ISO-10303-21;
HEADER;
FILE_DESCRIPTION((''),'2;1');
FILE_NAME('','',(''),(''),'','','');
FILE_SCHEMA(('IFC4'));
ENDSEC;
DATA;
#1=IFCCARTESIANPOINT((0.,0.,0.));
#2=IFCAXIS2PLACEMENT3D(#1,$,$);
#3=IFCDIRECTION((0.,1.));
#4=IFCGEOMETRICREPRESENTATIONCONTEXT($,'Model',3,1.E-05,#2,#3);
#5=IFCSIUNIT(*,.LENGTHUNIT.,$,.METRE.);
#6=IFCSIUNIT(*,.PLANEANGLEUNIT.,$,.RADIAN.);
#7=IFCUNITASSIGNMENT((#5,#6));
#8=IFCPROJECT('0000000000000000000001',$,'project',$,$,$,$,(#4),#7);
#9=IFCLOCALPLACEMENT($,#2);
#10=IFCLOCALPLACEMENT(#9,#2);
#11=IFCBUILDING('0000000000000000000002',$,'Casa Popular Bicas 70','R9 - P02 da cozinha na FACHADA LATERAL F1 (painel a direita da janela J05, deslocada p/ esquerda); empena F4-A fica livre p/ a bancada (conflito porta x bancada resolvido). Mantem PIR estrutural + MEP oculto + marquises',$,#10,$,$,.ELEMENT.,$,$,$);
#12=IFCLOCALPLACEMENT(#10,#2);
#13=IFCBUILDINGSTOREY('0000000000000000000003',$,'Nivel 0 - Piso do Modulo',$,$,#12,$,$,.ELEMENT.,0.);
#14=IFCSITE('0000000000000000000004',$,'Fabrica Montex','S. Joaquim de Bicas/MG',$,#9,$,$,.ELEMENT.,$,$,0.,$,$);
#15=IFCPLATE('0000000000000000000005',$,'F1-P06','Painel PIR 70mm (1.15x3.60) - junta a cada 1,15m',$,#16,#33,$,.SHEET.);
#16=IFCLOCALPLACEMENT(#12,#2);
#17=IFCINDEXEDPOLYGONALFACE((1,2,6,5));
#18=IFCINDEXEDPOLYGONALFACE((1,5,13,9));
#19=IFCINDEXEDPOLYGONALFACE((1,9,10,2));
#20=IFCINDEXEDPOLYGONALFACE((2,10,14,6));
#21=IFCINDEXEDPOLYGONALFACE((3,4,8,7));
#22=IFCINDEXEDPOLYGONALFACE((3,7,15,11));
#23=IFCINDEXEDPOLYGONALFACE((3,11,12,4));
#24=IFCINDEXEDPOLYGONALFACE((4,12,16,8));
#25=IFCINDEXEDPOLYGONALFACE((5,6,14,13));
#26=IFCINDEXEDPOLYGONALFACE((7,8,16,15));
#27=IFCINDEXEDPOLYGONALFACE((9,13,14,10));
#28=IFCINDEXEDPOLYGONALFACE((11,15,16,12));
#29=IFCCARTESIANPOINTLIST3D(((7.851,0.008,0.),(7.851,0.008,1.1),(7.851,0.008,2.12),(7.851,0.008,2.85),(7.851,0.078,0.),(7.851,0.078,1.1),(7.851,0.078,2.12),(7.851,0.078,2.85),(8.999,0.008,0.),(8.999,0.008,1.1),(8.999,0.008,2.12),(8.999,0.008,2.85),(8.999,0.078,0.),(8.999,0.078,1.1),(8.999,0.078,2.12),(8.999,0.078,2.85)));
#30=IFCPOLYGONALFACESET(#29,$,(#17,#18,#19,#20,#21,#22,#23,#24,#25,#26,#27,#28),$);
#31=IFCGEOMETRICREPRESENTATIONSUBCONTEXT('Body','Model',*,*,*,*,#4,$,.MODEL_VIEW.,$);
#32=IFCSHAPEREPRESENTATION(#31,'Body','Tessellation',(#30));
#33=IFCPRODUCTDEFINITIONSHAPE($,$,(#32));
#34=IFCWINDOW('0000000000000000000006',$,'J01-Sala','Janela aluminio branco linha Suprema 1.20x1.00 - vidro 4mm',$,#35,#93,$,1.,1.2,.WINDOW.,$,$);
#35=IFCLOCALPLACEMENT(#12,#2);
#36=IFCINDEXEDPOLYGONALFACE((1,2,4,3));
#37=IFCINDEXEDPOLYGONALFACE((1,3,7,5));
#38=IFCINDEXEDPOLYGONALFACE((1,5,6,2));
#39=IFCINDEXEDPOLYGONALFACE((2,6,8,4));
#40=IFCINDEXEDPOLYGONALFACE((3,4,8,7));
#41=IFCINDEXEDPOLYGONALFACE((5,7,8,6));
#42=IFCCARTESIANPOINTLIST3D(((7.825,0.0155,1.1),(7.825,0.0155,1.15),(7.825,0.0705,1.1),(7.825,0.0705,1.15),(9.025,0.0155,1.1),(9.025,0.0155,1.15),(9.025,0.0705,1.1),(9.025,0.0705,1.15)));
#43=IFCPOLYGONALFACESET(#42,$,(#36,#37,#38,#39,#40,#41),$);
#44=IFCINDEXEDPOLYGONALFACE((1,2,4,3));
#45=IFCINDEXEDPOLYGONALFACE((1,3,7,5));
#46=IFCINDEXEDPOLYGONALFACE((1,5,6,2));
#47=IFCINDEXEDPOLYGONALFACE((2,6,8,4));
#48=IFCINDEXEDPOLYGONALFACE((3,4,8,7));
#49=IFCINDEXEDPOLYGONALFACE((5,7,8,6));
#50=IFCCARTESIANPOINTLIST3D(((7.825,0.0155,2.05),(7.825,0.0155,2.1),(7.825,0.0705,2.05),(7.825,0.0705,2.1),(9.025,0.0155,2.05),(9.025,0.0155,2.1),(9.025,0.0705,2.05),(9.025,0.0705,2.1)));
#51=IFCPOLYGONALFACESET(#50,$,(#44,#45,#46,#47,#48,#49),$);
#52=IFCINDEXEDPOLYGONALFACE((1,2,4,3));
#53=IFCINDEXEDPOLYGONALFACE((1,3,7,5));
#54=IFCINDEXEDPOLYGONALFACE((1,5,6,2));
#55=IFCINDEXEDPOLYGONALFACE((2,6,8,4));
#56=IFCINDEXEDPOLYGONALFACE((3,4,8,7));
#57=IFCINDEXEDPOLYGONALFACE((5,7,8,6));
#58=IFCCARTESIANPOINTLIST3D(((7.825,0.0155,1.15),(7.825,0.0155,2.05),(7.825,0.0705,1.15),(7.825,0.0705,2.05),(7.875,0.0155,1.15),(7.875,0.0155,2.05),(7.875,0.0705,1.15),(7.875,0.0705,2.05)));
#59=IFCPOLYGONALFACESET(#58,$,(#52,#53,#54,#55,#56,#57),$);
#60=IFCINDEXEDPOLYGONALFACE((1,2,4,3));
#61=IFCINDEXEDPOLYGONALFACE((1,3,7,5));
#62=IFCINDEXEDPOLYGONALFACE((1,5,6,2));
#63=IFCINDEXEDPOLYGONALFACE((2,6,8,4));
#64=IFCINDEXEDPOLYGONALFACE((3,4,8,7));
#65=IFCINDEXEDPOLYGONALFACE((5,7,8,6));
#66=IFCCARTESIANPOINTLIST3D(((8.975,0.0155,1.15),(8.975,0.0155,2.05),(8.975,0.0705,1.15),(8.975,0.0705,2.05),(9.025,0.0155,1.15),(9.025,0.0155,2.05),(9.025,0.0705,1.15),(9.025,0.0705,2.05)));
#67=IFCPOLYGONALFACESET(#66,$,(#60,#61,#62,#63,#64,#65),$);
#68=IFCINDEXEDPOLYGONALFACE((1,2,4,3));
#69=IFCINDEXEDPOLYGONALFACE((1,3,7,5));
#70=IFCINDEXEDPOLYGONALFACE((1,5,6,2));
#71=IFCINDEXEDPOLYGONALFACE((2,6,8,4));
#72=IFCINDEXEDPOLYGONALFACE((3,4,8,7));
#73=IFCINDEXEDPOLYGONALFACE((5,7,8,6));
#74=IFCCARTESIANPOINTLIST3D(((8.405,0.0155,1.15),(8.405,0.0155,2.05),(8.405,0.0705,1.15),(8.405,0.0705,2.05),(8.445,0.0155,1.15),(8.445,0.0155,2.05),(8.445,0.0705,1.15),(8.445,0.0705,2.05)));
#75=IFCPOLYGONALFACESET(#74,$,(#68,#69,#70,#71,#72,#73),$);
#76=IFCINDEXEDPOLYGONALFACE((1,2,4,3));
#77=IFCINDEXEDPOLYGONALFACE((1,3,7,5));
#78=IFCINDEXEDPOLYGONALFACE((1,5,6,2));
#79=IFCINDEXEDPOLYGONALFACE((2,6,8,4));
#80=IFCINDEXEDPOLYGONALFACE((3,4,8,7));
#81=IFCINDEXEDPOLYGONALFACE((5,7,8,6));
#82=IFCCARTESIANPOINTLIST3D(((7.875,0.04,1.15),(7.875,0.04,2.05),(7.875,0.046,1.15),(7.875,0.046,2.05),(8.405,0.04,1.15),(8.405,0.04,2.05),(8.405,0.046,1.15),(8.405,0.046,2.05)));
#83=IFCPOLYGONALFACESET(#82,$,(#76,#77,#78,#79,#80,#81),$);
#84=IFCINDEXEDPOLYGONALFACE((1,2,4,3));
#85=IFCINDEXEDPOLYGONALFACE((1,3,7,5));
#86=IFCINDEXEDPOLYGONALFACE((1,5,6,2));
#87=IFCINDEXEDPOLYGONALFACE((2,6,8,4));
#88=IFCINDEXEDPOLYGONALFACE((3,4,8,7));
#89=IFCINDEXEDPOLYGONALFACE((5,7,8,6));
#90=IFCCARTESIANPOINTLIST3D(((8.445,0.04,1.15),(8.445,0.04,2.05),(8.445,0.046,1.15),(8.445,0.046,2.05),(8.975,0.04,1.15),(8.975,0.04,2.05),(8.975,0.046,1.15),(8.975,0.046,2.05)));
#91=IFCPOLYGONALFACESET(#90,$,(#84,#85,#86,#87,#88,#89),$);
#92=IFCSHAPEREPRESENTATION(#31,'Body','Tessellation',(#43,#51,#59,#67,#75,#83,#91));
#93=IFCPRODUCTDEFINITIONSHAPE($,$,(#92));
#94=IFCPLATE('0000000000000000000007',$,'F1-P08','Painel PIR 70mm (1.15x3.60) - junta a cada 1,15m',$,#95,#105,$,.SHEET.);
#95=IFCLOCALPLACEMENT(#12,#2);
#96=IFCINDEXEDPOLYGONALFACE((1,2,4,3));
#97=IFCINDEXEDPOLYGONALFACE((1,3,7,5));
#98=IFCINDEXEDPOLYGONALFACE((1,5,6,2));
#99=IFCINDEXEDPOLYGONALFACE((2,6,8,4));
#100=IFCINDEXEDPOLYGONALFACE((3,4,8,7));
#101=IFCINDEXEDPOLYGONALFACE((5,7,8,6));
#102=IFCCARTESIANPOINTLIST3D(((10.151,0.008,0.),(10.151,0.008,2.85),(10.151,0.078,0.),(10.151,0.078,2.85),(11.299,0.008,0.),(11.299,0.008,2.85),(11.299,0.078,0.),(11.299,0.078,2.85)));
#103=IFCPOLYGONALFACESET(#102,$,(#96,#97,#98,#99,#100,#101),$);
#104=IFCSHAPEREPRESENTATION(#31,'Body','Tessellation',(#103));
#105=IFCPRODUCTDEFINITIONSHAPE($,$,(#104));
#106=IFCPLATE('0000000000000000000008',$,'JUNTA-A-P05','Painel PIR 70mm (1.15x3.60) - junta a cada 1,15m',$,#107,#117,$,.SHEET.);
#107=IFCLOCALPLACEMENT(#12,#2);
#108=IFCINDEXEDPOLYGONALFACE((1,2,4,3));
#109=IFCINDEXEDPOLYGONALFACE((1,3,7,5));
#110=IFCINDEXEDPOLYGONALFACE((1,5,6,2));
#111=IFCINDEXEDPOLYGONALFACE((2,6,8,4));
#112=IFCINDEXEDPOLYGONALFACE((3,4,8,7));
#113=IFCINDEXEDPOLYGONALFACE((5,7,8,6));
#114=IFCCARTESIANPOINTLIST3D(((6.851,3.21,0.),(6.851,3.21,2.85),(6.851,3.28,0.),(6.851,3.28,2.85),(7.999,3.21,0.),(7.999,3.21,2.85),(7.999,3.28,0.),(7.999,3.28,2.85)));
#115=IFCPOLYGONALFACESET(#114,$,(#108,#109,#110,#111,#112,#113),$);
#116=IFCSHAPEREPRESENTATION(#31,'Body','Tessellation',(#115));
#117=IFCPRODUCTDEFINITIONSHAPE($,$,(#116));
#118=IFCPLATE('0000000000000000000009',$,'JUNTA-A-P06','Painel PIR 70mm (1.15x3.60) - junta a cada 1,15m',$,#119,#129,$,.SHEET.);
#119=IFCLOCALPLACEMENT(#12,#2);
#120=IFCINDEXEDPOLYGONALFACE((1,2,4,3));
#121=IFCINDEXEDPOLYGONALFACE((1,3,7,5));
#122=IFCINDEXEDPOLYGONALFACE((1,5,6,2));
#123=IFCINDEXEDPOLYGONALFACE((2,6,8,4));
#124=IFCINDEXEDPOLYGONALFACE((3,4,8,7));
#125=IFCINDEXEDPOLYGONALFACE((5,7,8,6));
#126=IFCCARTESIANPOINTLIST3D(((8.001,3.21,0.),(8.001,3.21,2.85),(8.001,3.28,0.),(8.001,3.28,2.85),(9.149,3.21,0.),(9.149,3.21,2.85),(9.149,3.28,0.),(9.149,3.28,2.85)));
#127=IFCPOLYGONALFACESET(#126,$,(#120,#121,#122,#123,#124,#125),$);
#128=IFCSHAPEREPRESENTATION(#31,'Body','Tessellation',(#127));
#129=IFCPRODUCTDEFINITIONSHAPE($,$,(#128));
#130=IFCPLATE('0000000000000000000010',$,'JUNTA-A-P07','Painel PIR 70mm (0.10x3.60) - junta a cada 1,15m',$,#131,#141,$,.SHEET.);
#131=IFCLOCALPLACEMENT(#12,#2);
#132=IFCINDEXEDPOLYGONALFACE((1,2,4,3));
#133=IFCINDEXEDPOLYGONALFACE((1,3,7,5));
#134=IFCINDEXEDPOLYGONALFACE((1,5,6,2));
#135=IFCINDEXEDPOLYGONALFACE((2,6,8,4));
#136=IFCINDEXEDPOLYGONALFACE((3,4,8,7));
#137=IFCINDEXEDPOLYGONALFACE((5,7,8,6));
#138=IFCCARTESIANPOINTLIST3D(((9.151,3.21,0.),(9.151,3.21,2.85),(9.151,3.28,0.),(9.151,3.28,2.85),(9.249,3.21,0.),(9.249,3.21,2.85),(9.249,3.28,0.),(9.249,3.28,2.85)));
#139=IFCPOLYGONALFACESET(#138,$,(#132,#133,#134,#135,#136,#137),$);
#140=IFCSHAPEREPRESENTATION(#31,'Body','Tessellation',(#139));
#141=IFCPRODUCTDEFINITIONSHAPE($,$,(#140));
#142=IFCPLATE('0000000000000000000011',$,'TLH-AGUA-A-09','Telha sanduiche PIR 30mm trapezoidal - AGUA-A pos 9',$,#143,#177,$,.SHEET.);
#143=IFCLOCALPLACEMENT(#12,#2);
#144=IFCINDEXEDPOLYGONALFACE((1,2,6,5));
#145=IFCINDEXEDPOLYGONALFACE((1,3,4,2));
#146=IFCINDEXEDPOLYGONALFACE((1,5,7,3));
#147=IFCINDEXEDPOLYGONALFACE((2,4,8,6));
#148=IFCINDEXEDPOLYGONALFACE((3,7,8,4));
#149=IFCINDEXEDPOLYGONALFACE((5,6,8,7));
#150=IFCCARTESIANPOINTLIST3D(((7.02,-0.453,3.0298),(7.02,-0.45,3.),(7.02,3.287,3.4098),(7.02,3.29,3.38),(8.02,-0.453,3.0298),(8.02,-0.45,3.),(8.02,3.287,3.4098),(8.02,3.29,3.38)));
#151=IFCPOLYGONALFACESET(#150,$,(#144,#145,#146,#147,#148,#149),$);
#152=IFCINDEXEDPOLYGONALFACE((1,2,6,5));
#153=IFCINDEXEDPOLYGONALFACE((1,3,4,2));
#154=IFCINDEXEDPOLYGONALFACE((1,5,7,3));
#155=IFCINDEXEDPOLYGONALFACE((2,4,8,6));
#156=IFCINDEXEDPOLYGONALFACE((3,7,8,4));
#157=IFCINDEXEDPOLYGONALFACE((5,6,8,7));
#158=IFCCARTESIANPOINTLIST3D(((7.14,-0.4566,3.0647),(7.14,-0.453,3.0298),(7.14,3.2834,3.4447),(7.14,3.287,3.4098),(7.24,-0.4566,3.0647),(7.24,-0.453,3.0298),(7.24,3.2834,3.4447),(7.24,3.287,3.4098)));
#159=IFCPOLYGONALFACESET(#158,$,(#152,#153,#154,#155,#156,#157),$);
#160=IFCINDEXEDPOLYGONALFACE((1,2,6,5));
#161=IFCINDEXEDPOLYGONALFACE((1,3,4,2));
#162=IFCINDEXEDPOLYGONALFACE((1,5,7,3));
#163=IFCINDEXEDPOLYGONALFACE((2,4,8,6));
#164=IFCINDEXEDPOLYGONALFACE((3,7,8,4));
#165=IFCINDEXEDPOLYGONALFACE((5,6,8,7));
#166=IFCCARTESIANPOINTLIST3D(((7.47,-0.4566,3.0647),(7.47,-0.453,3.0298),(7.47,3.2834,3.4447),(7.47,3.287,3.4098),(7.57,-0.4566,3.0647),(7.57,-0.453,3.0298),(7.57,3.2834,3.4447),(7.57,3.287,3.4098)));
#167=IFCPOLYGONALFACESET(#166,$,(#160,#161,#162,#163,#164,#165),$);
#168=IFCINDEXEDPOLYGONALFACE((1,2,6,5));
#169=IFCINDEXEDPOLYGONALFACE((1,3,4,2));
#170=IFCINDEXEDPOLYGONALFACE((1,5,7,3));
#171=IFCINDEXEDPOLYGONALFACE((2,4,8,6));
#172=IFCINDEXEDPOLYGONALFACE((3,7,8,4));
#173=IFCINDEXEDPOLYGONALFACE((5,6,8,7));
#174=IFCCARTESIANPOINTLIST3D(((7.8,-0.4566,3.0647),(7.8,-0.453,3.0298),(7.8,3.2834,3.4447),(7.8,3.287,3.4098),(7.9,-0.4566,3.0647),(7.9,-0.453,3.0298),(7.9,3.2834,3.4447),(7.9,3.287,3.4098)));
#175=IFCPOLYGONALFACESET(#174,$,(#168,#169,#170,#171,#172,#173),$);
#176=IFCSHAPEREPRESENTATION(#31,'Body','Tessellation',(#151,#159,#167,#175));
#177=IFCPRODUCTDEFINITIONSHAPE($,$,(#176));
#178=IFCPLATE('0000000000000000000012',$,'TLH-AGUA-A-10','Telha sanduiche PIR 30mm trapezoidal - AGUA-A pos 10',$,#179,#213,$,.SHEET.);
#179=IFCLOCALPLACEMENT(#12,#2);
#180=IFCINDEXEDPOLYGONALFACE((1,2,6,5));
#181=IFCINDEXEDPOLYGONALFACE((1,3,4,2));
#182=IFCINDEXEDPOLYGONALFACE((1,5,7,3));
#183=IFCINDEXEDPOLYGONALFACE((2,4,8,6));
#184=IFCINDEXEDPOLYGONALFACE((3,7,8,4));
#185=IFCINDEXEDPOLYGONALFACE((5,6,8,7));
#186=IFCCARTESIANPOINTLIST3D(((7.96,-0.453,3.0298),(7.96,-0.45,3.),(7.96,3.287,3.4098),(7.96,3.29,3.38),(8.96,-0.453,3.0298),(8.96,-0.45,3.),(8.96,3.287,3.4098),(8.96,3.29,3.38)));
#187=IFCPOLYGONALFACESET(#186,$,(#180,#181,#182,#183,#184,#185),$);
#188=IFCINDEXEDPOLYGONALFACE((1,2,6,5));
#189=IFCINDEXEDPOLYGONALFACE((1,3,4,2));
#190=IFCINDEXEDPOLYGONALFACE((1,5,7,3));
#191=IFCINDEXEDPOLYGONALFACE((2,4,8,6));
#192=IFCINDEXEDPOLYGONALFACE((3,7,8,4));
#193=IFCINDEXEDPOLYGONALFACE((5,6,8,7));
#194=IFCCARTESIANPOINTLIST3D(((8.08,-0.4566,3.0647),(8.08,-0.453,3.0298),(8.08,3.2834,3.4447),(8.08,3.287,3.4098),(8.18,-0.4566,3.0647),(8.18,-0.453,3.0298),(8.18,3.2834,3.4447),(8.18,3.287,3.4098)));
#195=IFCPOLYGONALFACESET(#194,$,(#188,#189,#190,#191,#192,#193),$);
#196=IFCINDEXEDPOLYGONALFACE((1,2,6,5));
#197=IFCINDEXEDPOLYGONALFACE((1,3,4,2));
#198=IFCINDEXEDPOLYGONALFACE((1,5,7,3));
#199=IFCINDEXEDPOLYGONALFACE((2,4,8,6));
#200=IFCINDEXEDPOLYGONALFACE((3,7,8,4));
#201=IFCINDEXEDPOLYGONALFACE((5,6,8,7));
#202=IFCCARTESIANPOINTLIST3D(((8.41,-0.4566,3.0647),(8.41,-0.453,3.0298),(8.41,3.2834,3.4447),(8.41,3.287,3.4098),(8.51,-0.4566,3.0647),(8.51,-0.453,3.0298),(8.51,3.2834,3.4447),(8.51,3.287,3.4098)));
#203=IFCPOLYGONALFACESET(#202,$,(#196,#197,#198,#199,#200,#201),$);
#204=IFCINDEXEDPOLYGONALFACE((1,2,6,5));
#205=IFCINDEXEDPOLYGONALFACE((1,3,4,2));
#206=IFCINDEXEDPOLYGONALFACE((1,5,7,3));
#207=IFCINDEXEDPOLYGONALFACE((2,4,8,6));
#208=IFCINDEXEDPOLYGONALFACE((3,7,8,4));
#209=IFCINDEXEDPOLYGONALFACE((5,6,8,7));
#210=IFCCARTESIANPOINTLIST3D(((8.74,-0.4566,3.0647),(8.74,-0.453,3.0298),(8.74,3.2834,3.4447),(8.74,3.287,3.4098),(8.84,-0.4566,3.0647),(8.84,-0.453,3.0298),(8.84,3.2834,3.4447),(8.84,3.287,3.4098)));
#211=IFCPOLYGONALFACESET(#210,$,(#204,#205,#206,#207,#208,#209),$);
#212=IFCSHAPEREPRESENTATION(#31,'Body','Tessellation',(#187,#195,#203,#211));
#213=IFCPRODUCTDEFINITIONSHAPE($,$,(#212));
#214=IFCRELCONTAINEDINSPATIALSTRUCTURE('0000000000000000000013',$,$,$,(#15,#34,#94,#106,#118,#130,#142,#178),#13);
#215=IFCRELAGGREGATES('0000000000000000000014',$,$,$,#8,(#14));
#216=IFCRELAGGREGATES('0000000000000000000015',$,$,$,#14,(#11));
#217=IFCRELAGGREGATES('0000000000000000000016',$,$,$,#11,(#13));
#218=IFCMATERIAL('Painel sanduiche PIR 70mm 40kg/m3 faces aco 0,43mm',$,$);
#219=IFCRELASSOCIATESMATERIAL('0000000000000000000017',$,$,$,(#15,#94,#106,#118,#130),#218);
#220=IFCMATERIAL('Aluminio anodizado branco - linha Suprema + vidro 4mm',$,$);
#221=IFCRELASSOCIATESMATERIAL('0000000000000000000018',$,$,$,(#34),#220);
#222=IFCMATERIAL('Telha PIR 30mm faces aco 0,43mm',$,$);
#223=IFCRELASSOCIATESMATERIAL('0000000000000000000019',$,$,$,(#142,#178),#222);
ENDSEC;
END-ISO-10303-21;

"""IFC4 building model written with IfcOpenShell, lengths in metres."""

from ifc_helpers import new_model, si_unit, direction, frame, frame_2d, origin, place, context, subcontext, project, spatial, rectangle, extrude, material, element, fill, save


model = new_model("IFC4")

# Units and contexts
model_context = context("Model", 3, precision=1e-05, world=origin(), true_north=direction((0.0, 1.0)))
body_context = subcontext(model_context, "Body", "Model", "MODEL_VIEW")
ifc_project = project(units=[si_unit("LENGTHUNIT", "METRE"), si_unit("PLANEANGLEUNIT", "RADIAN")], contexts=[model_context])

# Site, building, storey
site_placement = place(None, origin())
site = spatial("IfcSite", under=ifc_project, at=site_placement, Name="Fabrica Montex", Description="S. Joaquim de Bicas/MG", CompositionType="ELEMENT", RefElevation=0.0)
building_placement = place(site_placement, origin())
building = spatial("IfcBuilding", under=site, at=building_placement, Name="Casa Popular Bicas 70", Description="R9 - P02 da cozinha na FACHADA LATERAL F1 (painel a direita da janela J05, deslocada p/ esquerda); empena F4-A fica livre p/ a bancada (conflito porta x bancada resolvido). Mantem PIR estrutural + MEP oculto + marquises", CompositionType="ELEMENT")
storey_placement = place(building_placement, origin())
storey = spatial("IfcBuildingStorey", under=building, at=storey_placement, Name="Nivel 0 - Piso do Modulo", CompositionType="ELEMENT", Elevation=0.0)

# Shared definitions
ifc_material_1 = material(Name="Painel sanduiche PIR 70mm 40kg/m3 faces aco 0,43mm")

# Plate, opening, window
plate_1_placement = place(storey_placement, frame((7.851, 0.043, 0.0), x_axis=(1.0, 0.0, 0.0)))
plate_1 = element("IfcPlate", 1, at=plate_1_placement, inside=storey, material=ifc_material_1, Name="F1-P06", Description="Painel PIR 70mm (1.15x3.60) - junta a cada 1,15m", PredefinedType="SHEET", context=body_context, shape_type="SweptSolid", body=[
    extrude(rectangle(XDim=1.148, YDim=0.07, at=frame_2d((0.574, 0.0))), origin(), (0.0, 0.0, 1.0), 2.85),
])
opening_1_placement = place(storey_placement, frame((7.825, 0.043, 1.1)))
opening_1 = element("IfcOpeningElement", 2, at=opening_1_placement, cuts=plate_1, PredefinedType="OPENING", context=body_context, shape_type="SweptSolid", body=[
    extrude(rectangle(XDim=1.22, YDim=0.3, at=frame_2d((0.6, 0.0))), origin(), (0.0, 0.0, 1.0), 1.02),
])
ifc_material_2 = material(Name="Aluminio anodizado branco - linha Suprema + vidro 4mm")
window_placement = place(storey_placement, frame((7.825, 0.043, 1.1), x_axis=(1.0, 0.0, 0.0)))
window = element("IfcWindow", 3, at=window_placement, inside=storey, material=ifc_material_2, Name="J01-Sala", Description="Janela aluminio branco linha Suprema 1.20x1.00 - vidro 4mm", OverallHeight=1.0, OverallWidth=1.2, PredefinedType="WINDOW", context=body_context, shape_type="SweptSolid", body=[
    extrude(rectangle(XDim=1.2, YDim=0.055, at=frame_2d((0.6, 0.0))), origin(), (0.0, 0.0, 1.0), 0.05),
    extrude(rectangle(XDim=1.2, YDim=0.055, at=frame_2d((0.6, 0.0))), frame((0.0, 0.0, 0.95)), (0.0, 0.0, 1.0), 0.05),
    extrude(rectangle(XDim=0.05, YDim=0.055, at=frame_2d((0.025, 0.0))), frame((0.0, 0.0, 0.05)), (0.0, 0.0, 1.0), 0.9),
    extrude(rectangle(XDim=0.05, YDim=0.055, at=frame_2d((1.175, 0.0))), frame((0.0, 0.0, 0.05)), (0.0, 0.0, 1.0), 0.9),
    extrude(rectangle(XDim=0.04, YDim=0.055, at=frame_2d((0.6, 0.0))), frame((0.0, 0.0, 0.05)), (0.0, 0.0, 1.0), 0.9),
    extrude(rectangle(XDim=0.53, YDim=0.006, at=frame_2d((0.315, 0.0))), frame((0.0, 0.0, 0.05)), (0.0, 0.0, 1.0), 0.9),
    extrude(rectangle(XDim=0.53, YDim=0.006, at=frame_2d((0.885, 0.0))), frame((0.0, 0.0, 0.05)), (0.0, 0.0, 1.0), 0.9),
])
fill(opening_1, window)

# Plates
for number, where, x_axis, name in (
    (4, (10.151, 0.043, 0.0), (1.0, 0.0, 0.0), "F1-P08"),
    (5, (6.851, 3.245, 0.0), (1.0, 0.0, 0.0), "JUNTA-A-P05"),
    (6, (8.001, 3.245, 0.0), (1.0, 0.0, 0.0), "JUNTA-A-P06"),
):
    element("IfcPlate", number, at=place(storey_placement, frame(where, x_axis=x_axis)), inside=storey, material=ifc_material_1, Name=name, Description="Painel PIR 70mm (1.15x3.60) - junta a cada 1,15m", PredefinedType="SHEET", context=body_context, shape_type="SweptSolid", body=[
        extrude(rectangle(XDim=1.148, YDim=0.07, at=frame_2d((0.574, 0.0))), origin(), (0.0, 0.0, 1.0), 2.85),
    ])
plate_2_placement = place(storey_placement, frame((9.151, 3.245, 0.0), x_axis=(1.0, 0.0, 0.0)))
element("IfcPlate", 7, at=plate_2_placement, inside=storey, material=ifc_material_1, Name="JUNTA-A-P07", Description="Painel PIR 70mm (0.10x3.60) - junta a cada 1,15m", PredefinedType="SHEET", context=body_context, shape_type="SweptSolid", body=[
    extrude(rectangle(XDim=0.098, YDim=0.07, at=frame_2d((0.049, 0.0))), origin(), (0.0, 0.0, 1.0), 2.85),
])
ifc_material_3 = material(Name="Telha PIR 30mm faces aco 0,43mm")
for number, where, z_axis, x_axis, name, description in (
    (8, (7.02, -0.45, 3.0), (0.0, -0.101084, 0.994878), (1.0, 0.0, 0.0), "TLH-AGUA-A-09", "Telha sanduiche PIR 30mm trapezoidal - AGUA-A pos 9"),
    (9, (7.96, -0.45, 3.0), (0.0, -0.101084, 0.994878), (1.0, 0.0, 0.0), "TLH-AGUA-A-10", "Telha sanduiche PIR 30mm trapezoidal - AGUA-A pos 10"),
):
    element("IfcPlate", number, at=place(storey_placement, frame(where, z_axis=z_axis, x_axis=x_axis)), inside=storey, material=ifc_material_3, Name=name, Description=description, PredefinedType="SHEET", context=body_context, shape_type="SweptSolid", body=[
        extrude(rectangle(XDim=1.0, YDim=3.7593, at=frame_2d((0.5, 1.8796))), origin(), (0.0, 0.0, 1.0), 0.03),
        extrude(rectangle(XDim=0.1, YDim=3.7593, at=frame_2d((0.17, 1.8796))), frame((0.0, 0.0, 0.03)), (0.0, 0.0, 1.0), 0.035),
        extrude(rectangle(XDim=0.1, YDim=3.7593, at=frame_2d((0.5, 1.8796))), frame((0.0, 0.0, 0.03)), (0.0, 0.0, 1.0), 0.035),
        extrude(rectangle(XDim=0.1, YDim=3.7593, at=frame_2d((0.83, 1.8796))), frame((0.0, 0.0, 0.03)), (0.0, 0.0, 1.0), 0.035),
    ])

save(model, "model.ifc")
